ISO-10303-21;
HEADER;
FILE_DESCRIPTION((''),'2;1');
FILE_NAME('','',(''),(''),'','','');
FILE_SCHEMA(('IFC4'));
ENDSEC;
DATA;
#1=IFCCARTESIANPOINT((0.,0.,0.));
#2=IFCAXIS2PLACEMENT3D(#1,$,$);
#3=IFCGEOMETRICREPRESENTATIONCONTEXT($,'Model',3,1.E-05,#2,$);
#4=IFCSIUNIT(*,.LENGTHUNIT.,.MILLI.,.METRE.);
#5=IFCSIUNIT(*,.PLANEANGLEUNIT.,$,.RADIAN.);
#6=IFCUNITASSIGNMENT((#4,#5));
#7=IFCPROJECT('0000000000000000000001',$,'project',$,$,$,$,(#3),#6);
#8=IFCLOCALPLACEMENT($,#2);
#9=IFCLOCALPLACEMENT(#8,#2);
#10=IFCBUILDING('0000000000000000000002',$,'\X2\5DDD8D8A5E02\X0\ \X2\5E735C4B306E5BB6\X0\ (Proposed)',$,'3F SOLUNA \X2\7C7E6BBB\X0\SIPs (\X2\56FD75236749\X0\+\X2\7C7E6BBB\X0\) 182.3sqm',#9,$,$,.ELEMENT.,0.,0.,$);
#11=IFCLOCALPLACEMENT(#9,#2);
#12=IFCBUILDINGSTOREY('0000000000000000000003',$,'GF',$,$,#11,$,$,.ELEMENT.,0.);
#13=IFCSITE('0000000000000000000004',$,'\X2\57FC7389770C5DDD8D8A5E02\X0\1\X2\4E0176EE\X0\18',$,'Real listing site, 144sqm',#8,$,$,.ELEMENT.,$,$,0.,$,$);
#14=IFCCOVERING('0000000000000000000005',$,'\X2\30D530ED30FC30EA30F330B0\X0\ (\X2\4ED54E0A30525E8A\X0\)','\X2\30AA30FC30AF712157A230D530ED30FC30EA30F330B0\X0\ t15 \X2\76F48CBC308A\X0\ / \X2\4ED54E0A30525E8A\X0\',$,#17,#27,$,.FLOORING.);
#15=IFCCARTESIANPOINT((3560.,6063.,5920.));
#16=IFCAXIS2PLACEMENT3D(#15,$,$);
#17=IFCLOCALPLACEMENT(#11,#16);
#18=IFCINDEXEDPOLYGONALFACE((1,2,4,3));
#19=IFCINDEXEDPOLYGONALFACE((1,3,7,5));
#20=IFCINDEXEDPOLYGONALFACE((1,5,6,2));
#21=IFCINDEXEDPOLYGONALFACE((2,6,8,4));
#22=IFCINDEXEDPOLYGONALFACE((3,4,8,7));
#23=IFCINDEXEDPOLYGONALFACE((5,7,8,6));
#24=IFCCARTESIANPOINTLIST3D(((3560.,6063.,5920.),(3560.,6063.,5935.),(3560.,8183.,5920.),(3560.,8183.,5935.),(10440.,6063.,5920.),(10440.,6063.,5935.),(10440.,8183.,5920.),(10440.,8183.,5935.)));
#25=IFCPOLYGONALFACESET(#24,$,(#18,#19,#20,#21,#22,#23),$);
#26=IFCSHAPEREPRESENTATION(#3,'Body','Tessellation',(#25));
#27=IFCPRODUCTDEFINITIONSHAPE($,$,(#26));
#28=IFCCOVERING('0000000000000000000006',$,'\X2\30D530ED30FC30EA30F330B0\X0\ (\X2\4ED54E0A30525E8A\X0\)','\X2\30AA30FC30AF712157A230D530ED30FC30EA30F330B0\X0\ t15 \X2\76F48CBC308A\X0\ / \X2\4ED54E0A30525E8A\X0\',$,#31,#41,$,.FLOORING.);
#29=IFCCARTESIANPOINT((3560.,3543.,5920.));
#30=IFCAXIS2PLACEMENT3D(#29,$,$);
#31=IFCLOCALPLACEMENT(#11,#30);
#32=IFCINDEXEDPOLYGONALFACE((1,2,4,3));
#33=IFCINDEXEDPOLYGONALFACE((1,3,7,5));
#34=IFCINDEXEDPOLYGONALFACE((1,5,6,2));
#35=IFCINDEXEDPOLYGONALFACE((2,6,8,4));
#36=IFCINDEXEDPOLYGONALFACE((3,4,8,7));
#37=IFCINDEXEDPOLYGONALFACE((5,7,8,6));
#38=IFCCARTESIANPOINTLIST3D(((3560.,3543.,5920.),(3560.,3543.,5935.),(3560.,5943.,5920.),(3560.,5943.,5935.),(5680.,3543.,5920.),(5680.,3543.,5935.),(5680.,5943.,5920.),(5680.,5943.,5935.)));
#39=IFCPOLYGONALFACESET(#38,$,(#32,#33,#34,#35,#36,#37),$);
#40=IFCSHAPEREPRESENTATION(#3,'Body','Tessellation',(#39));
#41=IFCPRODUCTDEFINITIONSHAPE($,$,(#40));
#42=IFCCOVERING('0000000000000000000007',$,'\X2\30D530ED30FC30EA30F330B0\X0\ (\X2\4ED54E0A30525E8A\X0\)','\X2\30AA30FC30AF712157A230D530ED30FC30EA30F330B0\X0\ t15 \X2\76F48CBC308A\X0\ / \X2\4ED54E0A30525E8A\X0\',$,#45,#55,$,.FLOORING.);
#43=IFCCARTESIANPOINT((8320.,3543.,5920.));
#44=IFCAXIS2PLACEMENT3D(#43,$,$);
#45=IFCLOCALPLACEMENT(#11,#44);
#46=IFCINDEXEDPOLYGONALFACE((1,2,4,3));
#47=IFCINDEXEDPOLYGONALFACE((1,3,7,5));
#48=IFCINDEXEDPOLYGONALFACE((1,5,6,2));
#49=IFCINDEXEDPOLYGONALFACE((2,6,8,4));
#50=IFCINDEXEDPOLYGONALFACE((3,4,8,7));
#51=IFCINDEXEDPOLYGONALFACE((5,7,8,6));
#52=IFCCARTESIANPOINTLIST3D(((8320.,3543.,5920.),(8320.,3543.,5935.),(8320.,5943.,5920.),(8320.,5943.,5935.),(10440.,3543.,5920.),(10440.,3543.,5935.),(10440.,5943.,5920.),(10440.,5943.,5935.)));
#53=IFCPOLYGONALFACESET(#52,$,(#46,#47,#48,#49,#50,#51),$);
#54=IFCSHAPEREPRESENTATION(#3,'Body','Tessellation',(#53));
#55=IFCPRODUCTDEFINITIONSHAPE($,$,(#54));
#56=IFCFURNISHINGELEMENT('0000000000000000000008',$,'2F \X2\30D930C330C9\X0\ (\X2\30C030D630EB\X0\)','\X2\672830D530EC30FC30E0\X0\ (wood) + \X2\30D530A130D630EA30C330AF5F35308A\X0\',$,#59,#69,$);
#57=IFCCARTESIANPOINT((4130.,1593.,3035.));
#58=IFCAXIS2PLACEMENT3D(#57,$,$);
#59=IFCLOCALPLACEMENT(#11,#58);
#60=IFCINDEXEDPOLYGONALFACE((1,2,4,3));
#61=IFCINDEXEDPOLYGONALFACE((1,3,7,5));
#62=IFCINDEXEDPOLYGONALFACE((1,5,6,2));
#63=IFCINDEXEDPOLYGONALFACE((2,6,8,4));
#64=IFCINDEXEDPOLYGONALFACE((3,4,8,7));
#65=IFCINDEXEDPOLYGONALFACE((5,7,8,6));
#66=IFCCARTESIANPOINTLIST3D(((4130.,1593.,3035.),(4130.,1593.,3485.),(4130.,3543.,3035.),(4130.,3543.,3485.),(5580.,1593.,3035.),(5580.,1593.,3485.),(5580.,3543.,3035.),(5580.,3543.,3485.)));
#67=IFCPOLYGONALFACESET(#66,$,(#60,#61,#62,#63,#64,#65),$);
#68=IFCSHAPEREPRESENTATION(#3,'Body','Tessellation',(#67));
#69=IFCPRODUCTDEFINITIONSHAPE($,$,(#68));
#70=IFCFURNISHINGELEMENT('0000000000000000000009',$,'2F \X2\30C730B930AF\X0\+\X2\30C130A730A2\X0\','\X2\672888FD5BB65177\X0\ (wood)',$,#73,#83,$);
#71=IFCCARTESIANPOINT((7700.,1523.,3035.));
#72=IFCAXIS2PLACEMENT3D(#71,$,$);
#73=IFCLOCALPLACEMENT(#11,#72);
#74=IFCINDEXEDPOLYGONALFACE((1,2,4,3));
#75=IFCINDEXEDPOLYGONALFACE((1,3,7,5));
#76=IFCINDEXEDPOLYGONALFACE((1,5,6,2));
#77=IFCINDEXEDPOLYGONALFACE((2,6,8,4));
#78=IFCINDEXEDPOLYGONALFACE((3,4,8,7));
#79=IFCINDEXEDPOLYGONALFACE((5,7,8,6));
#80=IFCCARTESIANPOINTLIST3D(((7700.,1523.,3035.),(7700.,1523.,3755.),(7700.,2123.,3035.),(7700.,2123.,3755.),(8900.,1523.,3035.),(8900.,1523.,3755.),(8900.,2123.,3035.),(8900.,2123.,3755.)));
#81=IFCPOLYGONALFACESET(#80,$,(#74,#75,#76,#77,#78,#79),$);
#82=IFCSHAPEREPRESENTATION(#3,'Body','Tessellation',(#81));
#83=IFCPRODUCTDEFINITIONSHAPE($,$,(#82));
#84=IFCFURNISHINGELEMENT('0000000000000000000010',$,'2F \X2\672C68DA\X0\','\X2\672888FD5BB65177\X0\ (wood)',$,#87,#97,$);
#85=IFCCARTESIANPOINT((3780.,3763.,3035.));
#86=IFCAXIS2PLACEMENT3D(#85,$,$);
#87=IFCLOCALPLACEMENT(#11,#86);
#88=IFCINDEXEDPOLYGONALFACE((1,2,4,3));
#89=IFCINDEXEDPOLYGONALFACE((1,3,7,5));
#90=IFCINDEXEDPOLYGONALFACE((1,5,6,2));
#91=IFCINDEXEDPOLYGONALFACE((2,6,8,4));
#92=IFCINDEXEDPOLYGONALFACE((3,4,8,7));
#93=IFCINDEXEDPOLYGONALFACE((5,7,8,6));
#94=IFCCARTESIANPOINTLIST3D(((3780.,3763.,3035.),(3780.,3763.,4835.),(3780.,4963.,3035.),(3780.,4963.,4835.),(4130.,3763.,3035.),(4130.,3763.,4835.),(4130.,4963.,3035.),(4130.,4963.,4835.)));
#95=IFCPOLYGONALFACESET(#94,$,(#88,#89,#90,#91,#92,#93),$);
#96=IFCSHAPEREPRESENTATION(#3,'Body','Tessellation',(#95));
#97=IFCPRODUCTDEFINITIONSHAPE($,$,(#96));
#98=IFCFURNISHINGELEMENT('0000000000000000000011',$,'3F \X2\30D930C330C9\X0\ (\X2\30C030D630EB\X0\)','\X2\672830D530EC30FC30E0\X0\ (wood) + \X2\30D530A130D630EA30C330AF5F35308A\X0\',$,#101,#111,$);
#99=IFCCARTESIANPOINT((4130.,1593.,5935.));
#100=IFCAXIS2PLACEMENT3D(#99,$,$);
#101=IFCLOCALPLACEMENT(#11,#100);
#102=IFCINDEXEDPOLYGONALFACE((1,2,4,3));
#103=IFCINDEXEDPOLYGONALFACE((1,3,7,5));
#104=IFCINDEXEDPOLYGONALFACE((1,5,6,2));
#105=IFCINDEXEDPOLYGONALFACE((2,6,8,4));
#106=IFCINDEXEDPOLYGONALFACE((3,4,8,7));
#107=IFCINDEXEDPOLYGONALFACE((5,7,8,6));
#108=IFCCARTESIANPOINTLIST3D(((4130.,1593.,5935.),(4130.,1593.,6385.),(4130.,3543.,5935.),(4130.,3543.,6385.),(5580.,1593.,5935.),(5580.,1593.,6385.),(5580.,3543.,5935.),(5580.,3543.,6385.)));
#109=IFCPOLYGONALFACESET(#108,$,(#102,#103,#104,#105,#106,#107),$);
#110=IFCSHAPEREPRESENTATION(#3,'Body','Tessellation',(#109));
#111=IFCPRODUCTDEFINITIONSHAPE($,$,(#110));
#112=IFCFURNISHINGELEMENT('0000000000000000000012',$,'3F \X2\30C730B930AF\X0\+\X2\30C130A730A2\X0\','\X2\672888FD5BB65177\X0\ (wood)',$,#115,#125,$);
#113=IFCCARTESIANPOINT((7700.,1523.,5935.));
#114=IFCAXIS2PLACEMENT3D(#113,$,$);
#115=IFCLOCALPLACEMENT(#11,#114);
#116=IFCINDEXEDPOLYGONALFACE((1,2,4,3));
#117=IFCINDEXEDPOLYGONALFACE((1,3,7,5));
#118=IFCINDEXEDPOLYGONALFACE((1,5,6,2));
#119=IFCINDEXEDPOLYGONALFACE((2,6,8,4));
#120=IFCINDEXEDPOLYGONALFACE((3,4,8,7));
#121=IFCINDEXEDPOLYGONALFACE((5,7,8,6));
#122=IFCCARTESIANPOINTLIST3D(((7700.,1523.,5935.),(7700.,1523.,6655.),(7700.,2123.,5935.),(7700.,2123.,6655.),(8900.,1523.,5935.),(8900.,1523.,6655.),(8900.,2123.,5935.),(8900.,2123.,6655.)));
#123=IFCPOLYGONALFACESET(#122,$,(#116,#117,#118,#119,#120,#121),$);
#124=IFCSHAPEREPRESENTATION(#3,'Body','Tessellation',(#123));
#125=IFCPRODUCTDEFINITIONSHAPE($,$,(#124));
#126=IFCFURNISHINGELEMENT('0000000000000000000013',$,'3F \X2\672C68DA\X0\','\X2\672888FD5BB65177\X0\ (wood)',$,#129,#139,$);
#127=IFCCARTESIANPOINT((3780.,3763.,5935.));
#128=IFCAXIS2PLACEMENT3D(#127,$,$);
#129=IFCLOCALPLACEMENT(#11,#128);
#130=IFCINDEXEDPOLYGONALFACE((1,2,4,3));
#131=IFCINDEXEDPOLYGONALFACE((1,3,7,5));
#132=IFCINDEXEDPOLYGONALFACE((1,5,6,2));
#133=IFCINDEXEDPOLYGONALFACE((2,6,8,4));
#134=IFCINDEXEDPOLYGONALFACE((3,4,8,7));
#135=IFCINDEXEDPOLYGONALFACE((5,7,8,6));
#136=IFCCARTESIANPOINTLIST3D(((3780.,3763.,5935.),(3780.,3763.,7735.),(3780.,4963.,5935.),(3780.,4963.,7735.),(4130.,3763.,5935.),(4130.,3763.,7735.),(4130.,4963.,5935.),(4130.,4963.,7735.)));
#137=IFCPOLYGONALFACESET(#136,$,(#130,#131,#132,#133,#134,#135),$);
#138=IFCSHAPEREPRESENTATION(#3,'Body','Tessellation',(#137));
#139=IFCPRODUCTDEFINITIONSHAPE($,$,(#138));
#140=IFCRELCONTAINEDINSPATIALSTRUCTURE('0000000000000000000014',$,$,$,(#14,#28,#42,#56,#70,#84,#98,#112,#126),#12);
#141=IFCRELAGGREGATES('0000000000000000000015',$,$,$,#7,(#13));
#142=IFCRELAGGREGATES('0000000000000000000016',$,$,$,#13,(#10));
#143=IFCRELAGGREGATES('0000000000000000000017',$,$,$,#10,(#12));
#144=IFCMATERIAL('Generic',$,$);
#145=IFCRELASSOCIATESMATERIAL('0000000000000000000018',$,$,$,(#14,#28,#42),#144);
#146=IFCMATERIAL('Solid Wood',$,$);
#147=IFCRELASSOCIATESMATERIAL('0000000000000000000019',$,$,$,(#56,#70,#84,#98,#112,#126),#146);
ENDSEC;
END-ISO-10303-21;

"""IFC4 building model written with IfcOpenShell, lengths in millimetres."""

from ifc_helpers import new_model, si_unit, frame, frame_2d, origin, place, context, project, spatial, rectangle, extrude, material, element, save


model = new_model("IFC4")

# Units and contexts
model_context = context("Model", 3, precision=1e-05, world=origin())
ifc_project = project(units=[si_unit("LENGTHUNIT", "METRE", prefix="MILLI"), si_unit("PLANEANGLEUNIT", "RADIAN")], contexts=[model_context])

# Site, building, storey
site_placement = place(None, origin())
site = spatial("IfcSite", under=ifc_project, at=site_placement, Name="埼玉県川越市1丁目18", ObjectType="Real listing site, 144sqm", CompositionType="ELEMENT", RefElevation=0.0)
building_placement = place(site_placement, origin())
building = spatial("IfcBuilding", under=site, at=building_placement, Name="川越市 平屋の家 (Proposed)", ObjectType="3F SOLUNA 籾殻SIPs (国産杉+籾殻) 182.3sqm", CompositionType="ELEMENT", ElevationOfRefHeight=0.0, ElevationOfTerrain=0.0)
storey_placement = place(building_placement, origin())
storey = spatial("IfcBuildingStorey", under=building, at=storey_placement, Name="GF", CompositionType="ELEMENT", Elevation=0.0)

# Shared definitions
ifc_material_1 = material(Name="Solid Wood")

# Shared definitions
ifc_material_2 = material(Name="Generic")

# Coverings
covering_1_placement = place(storey_placement, frame((3560.0, 6063.0, 5920.0)))
element("IfcCovering", 1, at=covering_1_placement, inside=storey, material=ifc_material_2, Name="フローリング (仕上げ床)", Description="オーク無垢フローリング t15 直貼り / 仕上げ床", PredefinedType="FLOORING", context=model_context, shape_type="SweptSolid", body=[
    extrude(rectangle(XDim=6880.0, YDim=2120.0, at=frame_2d((3440.0, 1060.0))), frame((3560.0, 6063.0, 5920.0)), (0.0, 0.0, 1.0), 15.0),
])
covering_2_placement = place(storey_placement, frame((3560.0, 3543.0, 5920.0)))
element("IfcCovering", 2, at=covering_2_placement, inside=storey, material=ifc_material_2, Name="フローリング (仕上げ床)", Description="オーク無垢フローリング t15 直貼り / 仕上げ床", PredefinedType="FLOORING", context=model_context, shape_type="SweptSolid", body=[
    extrude(rectangle(XDim=2120.0, YDim=2400.0, at=frame_2d((1060.0, 1200.0))), frame((3560.0, 3543.0, 5920.0)), (0.0, 0.0, 1.0), 15.0),
])
covering_3_placement = place(storey_placement, frame((8320.0, 3543.0, 5920.0)))
element("IfcCovering", 3, at=covering_3_placement, inside=storey, material=ifc_material_2, Name="フローリング (仕上げ床)", Description="オーク無垢フローリング t15 直貼り / 仕上げ床", PredefinedType="FLOORING", context=model_context, shape_type="SweptSolid", body=[
    extrude(rectangle(XDim=2120.0, YDim=2400.0, at=frame_2d((1060.0, 1200.0))), frame((8320.0, 3543.0, 5920.0)), (0.0, 0.0, 1.0), 15.0),
])

# Furnishing elements
furnishing_1_placement = place(storey_placement, frame((4130.0, 1593.0, 3035.0)))
element("IfcFurnishingElement", 4, at=furnishing_1_placement, inside=storey, material=ifc_material_1, Name="2F ベッド (ダブル)", Description="木フレーム (wood) + ファブリック張り", context=model_context, shape_type="SweptSolid", body=[
    extrude(rectangle(XDim=1450.0, YDim=1950.0, at=frame_2d((725.0, 975.0))), frame((4130.0, 1593.0, 3035.0)), (0.0, 0.0, 1.0), 450.0),
])
furnishing_2_placement = place(storey_placement, frame((7700.0, 1523.0, 3035.0)))
element("IfcFurnishingElement", 5, at=furnishing_2_placement, inside=storey, material=ifc_material_1, Name="2F デスク+チェア", Description="木製家具 (wood)", context=model_context, shape_type="SweptSolid", body=[
    extrude(rectangle(XDim=1200.0, YDim=600.0, at=frame_2d((600.0, 300.0))), frame((7700.0, 1523.0, 3035.0)), (0.0, 0.0, 1.0), 720.0),
])
furnishing_3_placement = place(storey_placement, frame((3780.0, 3763.0, 3035.0)))
element("IfcFurnishingElement", 6, at=furnishing_3_placement, inside=storey, material=ifc_material_1, Name="2F 本棚", Description="木製家具 (wood)", context=model_context, shape_type="SweptSolid", body=[
    extrude(rectangle(XDim=350.0, YDim=1200.0, at=frame_2d((175.0, 600.0))), frame((3780.0, 3763.0, 3035.0)), (0.0, 0.0, 1.0), 1800.0),
])
furnishing_4_placement = place(storey_placement, frame((4130.0, 1593.0, 5935.0)))
element("IfcFurnishingElement", 7, at=furnishing_4_placement, inside=storey, material=ifc_material_1, Name="3F ベッド (ダブル)", Description="木フレーム (wood) + ファブリック張り", context=model_context, shape_type="SweptSolid", body=[
    extrude(rectangle(XDim=1450.0, YDim=1950.0, at=frame_2d((725.0, 975.0))), frame((4130.0, 1593.0, 5935.0)), (0.0, 0.0, 1.0), 450.0),
])
furnishing_5_placement = place(storey_placement, frame((7700.0, 1523.0, 5935.0)))
element("IfcFurnishingElement", 8, at=furnishing_5_placement, inside=storey, material=ifc_material_1, Name="3F デスク+チェア", Description="木製家具 (wood)", context=model_context, shape_type="SweptSolid", body=[
    extrude(rectangle(XDim=1200.0, YDim=600.0, at=frame_2d((600.0, 300.0))), frame((7700.0, 1523.0, 5935.0)), (0.0, 0.0, 1.0), 720.0),
])
furnishing_6_placement = place(storey_placement, frame((3780.0, 3763.0, 5935.0)))
element("IfcFurnishingElement", 9, at=furnishing_6_placement, inside=storey, material=ifc_material_1, Name="3F 本棚", Description="木製家具 (wood)", context=model_context, shape_type="SweptSolid", body=[
    extrude(rectangle(XDim=350.0, YDim=1200.0, at=frame_2d((175.0, 600.0))), frame((3780.0, 3763.0, 5935.0)), (0.0, 0.0, 1.0), 1800.0),
])

save(model, "model.ifc")
